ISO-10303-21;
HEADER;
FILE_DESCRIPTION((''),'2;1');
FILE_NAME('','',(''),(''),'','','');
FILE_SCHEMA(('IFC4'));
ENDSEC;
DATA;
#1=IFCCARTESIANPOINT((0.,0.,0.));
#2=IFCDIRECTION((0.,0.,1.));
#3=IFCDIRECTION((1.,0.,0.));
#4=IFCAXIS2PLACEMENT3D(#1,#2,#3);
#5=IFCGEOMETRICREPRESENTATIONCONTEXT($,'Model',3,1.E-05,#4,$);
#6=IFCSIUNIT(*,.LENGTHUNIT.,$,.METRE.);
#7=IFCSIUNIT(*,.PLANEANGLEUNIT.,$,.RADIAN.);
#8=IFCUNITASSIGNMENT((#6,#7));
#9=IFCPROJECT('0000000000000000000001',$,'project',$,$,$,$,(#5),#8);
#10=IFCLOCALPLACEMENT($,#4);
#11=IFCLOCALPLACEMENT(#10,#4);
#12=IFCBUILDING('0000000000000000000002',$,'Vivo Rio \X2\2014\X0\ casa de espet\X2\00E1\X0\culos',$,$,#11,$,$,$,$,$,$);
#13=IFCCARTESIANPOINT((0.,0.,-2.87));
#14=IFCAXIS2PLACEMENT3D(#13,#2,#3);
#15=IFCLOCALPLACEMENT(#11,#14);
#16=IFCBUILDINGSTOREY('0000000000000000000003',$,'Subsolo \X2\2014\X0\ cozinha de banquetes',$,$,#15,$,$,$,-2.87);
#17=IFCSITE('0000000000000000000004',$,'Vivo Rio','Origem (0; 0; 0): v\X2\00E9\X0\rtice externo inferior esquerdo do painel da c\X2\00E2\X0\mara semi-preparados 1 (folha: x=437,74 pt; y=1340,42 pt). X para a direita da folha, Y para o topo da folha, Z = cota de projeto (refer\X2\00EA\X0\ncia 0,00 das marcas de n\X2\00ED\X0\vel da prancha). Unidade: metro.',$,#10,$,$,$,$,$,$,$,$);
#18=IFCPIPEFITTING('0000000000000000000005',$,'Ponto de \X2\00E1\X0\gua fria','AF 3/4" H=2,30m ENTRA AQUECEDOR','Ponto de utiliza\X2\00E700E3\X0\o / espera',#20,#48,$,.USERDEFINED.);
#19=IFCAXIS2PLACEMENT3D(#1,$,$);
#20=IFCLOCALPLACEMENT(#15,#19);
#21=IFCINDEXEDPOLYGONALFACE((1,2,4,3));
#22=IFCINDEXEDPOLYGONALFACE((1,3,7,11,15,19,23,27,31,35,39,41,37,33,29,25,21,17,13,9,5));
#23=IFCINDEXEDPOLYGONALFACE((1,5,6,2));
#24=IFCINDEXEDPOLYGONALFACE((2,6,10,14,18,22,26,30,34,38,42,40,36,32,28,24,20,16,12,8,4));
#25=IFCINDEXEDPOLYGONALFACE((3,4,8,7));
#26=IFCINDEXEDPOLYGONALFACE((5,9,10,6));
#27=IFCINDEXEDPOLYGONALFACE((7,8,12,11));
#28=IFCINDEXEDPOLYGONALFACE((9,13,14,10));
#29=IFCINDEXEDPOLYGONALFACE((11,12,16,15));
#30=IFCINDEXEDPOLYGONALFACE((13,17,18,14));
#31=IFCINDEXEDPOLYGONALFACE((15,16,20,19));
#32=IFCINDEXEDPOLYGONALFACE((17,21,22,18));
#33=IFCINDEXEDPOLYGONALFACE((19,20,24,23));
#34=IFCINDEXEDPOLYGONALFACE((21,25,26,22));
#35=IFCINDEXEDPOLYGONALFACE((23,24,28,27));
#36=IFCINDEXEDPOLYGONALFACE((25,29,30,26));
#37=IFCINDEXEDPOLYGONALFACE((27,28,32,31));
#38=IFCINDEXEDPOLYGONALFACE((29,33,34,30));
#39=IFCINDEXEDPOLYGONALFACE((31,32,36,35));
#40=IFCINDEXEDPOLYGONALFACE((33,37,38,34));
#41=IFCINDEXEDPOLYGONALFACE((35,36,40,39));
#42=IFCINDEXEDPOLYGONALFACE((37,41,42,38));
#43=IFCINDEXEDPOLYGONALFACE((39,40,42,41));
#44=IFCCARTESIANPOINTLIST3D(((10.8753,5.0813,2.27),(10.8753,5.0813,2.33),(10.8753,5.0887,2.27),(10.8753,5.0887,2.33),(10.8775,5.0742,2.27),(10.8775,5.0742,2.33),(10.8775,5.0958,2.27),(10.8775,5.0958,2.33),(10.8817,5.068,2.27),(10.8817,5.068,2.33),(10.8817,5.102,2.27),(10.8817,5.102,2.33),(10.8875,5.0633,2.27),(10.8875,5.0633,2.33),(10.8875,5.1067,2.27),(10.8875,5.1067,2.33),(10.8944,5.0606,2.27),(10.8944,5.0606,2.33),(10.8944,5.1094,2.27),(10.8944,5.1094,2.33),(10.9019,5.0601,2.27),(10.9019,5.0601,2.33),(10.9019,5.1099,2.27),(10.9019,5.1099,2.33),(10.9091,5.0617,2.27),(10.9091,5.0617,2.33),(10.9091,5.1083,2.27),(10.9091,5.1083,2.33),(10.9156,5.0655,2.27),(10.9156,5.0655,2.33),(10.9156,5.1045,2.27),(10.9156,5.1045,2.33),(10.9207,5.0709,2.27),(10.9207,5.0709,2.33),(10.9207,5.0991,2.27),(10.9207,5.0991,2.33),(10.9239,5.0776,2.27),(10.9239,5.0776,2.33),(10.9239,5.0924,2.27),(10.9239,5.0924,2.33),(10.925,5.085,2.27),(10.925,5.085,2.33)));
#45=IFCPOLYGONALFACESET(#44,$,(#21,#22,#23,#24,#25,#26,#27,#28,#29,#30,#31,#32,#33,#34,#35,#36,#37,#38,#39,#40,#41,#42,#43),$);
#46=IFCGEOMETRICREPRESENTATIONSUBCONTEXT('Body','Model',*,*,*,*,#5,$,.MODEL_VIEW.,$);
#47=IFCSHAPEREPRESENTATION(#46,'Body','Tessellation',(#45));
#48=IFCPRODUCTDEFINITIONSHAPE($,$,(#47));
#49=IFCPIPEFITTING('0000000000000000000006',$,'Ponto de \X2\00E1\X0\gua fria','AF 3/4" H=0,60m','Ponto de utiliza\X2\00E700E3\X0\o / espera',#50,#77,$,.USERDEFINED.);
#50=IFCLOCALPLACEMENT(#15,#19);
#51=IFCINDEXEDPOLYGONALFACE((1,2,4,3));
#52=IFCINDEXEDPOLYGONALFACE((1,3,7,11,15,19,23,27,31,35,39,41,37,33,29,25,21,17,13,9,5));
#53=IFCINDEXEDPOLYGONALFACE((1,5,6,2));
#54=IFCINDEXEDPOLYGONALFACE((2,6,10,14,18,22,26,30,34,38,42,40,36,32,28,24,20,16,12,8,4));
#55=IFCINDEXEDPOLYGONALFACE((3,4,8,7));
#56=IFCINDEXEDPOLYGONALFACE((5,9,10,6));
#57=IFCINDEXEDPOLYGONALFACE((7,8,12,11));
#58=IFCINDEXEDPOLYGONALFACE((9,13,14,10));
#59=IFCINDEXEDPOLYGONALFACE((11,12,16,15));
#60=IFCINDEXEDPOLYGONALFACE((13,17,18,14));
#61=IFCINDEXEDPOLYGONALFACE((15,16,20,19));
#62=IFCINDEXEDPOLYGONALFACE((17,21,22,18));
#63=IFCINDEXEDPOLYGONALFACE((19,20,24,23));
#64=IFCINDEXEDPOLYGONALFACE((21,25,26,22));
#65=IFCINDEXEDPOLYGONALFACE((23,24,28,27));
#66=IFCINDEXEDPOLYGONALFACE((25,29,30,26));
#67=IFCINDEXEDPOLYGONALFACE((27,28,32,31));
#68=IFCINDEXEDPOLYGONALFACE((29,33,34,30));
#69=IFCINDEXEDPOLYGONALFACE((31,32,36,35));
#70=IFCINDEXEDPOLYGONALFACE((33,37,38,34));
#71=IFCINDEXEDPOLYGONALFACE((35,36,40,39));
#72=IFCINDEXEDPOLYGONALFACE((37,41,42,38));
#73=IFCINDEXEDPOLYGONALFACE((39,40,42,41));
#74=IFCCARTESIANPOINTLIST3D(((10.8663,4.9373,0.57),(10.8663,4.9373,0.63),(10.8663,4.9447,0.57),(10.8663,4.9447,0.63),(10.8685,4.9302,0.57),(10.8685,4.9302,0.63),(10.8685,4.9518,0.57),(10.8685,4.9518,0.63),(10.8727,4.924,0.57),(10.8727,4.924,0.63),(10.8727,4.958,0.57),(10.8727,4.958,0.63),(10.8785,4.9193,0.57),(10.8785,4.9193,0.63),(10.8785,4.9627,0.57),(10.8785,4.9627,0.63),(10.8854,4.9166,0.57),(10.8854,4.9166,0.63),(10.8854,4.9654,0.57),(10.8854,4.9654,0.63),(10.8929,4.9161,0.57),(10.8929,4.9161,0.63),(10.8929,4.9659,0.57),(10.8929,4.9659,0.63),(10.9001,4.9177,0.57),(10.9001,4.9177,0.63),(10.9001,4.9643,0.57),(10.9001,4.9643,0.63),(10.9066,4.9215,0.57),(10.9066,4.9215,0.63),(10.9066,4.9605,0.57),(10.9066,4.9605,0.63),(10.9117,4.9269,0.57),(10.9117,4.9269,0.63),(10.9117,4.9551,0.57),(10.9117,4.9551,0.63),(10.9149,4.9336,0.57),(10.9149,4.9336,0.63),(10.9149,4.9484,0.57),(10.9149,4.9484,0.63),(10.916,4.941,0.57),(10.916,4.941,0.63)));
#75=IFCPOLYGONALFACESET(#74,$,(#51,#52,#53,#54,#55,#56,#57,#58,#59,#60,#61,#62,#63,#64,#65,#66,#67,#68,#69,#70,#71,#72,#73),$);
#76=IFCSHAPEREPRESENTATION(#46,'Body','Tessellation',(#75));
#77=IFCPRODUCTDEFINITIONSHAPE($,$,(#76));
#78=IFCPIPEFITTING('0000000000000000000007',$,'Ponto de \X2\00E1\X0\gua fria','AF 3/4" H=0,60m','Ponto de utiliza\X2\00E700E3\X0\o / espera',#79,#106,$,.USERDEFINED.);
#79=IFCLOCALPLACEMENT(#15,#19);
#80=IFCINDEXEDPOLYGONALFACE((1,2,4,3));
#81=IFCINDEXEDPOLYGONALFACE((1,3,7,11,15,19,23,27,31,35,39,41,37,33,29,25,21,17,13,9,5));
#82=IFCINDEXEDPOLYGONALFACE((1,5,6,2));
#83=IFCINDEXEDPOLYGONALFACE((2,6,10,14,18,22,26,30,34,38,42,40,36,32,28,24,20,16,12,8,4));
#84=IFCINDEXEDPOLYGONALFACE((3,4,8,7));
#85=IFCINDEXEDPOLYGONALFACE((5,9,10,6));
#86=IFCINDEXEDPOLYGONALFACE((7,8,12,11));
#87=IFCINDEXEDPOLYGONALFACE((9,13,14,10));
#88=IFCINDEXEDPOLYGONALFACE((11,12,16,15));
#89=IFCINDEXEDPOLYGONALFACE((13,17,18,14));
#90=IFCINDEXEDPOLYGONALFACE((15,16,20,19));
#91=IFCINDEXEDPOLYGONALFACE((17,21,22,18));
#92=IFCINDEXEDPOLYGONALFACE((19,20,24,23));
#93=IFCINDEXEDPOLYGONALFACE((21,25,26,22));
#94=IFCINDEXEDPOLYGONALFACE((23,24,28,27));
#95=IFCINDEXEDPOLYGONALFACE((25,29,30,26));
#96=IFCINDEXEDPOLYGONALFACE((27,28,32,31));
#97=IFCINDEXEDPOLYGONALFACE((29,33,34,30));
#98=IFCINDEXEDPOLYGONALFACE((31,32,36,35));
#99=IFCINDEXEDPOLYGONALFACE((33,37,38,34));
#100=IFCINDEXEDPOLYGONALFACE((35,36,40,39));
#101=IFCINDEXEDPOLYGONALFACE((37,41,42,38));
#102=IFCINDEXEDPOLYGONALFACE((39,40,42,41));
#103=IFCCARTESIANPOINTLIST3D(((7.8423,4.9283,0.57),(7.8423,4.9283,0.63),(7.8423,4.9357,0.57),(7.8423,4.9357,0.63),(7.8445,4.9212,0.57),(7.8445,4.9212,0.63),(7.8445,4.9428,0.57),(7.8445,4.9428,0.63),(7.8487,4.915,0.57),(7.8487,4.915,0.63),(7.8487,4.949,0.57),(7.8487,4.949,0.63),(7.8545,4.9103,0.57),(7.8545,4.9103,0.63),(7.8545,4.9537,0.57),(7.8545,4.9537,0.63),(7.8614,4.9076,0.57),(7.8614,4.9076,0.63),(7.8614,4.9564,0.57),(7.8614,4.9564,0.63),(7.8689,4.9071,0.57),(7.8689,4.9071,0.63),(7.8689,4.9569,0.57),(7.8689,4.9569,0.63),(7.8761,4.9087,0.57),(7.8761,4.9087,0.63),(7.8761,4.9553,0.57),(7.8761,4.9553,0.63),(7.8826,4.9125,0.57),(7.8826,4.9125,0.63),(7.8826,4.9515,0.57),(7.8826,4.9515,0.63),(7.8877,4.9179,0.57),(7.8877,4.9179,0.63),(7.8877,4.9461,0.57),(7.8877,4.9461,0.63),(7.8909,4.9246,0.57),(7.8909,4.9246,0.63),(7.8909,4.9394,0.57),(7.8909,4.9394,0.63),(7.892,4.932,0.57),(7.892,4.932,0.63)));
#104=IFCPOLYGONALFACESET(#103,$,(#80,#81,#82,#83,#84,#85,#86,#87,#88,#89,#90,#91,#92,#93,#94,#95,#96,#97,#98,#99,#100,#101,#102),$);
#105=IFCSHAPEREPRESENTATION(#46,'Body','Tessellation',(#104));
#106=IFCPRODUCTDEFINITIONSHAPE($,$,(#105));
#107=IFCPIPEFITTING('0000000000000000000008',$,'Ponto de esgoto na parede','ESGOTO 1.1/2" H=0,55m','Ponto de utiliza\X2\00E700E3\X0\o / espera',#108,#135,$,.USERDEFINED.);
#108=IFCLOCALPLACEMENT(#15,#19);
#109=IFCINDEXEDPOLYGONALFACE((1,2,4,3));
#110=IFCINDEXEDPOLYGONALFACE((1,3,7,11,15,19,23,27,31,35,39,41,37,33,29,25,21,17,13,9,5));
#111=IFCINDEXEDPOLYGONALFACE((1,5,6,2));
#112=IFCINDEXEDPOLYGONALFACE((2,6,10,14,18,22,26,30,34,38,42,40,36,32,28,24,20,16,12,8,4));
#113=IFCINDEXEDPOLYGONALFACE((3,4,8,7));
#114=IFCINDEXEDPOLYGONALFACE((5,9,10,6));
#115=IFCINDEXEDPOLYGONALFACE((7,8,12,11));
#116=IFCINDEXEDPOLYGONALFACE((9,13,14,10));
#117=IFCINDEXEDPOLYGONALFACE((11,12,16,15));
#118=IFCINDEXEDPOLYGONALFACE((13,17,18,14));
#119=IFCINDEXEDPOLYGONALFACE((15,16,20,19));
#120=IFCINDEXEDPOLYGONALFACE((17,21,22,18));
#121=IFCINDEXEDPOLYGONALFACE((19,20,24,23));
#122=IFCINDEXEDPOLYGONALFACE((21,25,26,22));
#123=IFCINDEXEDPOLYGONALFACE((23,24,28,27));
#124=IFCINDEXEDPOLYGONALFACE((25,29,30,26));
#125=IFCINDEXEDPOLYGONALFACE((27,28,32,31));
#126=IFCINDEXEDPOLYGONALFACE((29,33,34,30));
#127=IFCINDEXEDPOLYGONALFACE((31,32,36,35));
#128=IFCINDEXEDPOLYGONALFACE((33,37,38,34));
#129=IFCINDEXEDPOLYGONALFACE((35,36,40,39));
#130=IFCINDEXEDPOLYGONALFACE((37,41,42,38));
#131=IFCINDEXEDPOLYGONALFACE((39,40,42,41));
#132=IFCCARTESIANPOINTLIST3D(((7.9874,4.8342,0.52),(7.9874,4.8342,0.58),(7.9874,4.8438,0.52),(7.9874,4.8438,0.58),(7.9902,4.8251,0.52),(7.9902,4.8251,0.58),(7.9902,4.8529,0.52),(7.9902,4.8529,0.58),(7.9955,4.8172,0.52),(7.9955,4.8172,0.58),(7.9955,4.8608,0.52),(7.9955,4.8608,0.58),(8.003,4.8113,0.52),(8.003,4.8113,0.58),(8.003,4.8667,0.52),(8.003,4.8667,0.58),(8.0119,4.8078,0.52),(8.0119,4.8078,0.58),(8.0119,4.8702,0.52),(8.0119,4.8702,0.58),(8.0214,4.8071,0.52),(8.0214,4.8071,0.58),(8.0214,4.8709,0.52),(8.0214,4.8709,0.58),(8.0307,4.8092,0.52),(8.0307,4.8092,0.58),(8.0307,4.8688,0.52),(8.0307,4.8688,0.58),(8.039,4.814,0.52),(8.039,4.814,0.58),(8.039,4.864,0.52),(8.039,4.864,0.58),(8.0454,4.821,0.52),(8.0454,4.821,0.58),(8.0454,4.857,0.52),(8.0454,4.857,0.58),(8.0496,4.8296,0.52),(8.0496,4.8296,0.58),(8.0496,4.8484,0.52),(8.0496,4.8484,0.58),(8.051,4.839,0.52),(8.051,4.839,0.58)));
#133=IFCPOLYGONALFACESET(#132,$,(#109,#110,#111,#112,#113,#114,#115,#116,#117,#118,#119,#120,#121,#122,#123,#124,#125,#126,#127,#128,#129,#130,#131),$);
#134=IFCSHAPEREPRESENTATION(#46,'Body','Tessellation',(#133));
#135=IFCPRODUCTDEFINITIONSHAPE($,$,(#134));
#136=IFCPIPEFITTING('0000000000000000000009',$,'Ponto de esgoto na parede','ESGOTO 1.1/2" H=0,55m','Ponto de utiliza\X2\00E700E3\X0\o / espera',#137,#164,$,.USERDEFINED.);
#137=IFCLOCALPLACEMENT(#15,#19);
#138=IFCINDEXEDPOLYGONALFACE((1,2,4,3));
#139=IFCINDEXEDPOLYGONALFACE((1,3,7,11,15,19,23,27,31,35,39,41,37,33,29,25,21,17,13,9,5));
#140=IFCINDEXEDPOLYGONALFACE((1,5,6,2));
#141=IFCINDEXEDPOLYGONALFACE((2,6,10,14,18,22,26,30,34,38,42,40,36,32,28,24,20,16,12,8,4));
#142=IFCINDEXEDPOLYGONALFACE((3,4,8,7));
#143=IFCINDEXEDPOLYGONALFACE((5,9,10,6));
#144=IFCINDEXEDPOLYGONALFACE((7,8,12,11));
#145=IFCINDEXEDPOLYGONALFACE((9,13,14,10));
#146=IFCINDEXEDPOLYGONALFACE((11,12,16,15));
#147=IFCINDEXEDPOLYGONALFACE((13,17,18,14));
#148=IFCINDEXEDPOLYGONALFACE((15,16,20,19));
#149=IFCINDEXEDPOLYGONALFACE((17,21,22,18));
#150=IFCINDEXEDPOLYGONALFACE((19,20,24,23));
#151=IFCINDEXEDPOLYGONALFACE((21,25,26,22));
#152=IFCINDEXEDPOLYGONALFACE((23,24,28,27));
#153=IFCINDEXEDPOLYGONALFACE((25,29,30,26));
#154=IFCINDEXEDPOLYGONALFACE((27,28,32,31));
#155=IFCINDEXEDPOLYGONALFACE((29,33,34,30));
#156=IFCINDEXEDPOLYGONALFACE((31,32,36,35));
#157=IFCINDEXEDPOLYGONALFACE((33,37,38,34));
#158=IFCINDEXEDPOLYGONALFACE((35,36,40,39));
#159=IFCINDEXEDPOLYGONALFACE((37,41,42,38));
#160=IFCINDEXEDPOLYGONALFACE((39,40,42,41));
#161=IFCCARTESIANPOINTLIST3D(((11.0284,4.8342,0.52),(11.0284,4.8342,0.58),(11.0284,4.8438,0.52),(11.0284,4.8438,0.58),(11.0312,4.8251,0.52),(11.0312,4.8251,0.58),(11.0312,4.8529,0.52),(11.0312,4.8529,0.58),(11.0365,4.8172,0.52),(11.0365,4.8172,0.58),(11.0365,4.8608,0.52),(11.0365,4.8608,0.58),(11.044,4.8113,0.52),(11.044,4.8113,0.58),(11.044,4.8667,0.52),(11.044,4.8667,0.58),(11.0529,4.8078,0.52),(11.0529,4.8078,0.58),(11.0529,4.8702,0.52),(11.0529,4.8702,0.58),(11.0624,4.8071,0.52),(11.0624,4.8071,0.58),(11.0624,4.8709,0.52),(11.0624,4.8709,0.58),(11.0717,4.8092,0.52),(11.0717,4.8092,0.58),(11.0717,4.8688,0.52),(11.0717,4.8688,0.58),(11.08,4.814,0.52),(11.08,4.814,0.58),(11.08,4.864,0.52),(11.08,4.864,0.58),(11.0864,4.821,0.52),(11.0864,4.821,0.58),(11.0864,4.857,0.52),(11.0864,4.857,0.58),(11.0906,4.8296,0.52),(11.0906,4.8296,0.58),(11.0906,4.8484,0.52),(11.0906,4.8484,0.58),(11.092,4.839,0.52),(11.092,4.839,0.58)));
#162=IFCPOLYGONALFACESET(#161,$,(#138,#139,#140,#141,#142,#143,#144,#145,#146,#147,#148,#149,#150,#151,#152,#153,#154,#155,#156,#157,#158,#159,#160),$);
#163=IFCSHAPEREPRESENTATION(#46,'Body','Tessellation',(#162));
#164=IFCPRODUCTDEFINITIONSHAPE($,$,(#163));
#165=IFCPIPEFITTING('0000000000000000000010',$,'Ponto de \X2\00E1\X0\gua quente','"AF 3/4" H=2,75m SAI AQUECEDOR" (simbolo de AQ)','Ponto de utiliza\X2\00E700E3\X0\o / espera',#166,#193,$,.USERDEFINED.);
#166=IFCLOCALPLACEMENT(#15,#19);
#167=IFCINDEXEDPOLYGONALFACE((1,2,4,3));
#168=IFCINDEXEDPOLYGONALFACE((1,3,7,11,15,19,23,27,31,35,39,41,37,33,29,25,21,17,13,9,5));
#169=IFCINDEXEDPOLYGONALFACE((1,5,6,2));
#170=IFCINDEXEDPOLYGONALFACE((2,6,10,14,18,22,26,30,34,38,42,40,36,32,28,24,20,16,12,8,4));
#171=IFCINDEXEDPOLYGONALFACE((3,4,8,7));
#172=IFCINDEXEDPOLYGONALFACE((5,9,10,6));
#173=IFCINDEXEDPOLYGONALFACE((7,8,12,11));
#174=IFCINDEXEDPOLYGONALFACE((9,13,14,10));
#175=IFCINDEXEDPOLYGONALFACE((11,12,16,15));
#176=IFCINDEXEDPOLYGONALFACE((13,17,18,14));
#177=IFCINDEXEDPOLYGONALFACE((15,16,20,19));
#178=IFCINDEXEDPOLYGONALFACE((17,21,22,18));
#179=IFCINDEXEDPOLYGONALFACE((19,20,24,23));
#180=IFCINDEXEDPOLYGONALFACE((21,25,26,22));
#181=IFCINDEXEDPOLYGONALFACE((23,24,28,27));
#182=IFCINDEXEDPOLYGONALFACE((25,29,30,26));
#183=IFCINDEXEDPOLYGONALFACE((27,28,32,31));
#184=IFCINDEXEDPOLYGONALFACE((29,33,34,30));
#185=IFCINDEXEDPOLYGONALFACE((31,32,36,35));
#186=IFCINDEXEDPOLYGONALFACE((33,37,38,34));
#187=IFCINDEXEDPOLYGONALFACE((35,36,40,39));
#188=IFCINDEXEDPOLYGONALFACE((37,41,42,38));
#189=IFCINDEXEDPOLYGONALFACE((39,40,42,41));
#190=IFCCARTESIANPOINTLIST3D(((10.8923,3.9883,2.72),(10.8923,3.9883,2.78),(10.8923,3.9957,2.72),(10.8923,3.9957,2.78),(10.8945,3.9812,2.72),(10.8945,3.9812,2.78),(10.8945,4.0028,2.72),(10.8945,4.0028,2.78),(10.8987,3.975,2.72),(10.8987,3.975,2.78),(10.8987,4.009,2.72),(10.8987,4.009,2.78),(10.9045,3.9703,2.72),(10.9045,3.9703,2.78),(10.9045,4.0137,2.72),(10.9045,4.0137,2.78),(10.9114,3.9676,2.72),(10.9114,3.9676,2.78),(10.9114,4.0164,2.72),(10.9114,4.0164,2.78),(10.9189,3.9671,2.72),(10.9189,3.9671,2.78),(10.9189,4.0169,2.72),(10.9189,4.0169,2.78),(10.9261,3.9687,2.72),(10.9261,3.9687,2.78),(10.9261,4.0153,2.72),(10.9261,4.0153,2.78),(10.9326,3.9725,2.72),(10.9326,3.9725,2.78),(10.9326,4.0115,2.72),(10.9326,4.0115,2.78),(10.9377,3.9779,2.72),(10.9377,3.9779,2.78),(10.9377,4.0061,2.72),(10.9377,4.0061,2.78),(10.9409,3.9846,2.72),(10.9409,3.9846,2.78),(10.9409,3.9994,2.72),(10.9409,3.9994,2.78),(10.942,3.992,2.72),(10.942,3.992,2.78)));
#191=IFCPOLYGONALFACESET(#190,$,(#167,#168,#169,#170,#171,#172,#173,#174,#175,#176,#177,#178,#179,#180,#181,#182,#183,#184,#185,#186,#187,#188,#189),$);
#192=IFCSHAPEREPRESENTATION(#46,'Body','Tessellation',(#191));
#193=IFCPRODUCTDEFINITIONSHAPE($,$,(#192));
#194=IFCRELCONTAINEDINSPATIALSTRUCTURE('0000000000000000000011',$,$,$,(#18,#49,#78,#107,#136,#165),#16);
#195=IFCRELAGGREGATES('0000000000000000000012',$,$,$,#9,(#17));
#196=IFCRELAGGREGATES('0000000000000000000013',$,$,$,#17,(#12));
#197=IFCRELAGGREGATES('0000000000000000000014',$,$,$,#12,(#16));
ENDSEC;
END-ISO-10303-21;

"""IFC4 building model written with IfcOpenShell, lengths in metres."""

from ifc_helpers import new_model, si_unit, frame, origin_with_axes, origin_2d, place, context, subcontext, project, spatial, circle, extrude, element, save


model = new_model("IFC4")

# Units and contexts
model_context = context("Model", 3, precision=1e-05, world=origin_with_axes())
body_context = subcontext(model_context, "Body", "Model", "MODEL_VIEW")
ifc_project = project(units=[si_unit("LENGTHUNIT", "METRE"), si_unit("PLANEANGLEUNIT", "RADIAN")], contexts=[model_context])

# Site, building, storey
site_placement = place(None, origin_with_axes())
site = spatial("IfcSite", under=ifc_project, at=site_placement, Name="Vivo Rio", Description="Origem (0; 0; 0): vértice externo inferior esquerdo do painel da câmara semi-preparados 1 (folha: x=437,74 pt; y=1340,42 pt). X para a direita da folha, Y para o topo da folha, Z = cota de projeto (referência 0,00 das marcas de nível da prancha). Unidade: metro.")
building_placement = place(site_placement, origin_with_axes())
building = spatial("IfcBuilding", under=site, at=building_placement, Name="Vivo Rio — casa de espetáculos")
storey_placement = place(building_placement, frame((0.0, 0.0, -2.87), z_axis=(0.0, 0.0, 1.0), x_axis=(1.0, 0.0, 0.0)))
storey = spatial("IfcBuildingStorey", under=building, at=storey_placement, Name="Subsolo — cozinha de banquetes", Elevation=-2.87)

# Pipe fittings
pipe_fitting_1_placement = place(storey_placement, origin_with_axes())
element("IfcPipeFitting", 1, at=pipe_fitting_1_placement, inside=storey, Name="Ponto de água fria", Description="AF 3/4\" H=2,30m ENTRA AQUECEDOR", ObjectType="Ponto de utilização / espera", PredefinedType="USERDEFINED", context=body_context, shape_type="SweptSolid", body=[
    extrude(circle(Radius=0.025, at=origin_2d()), frame((10.9, 5.085, 2.27), z_axis=(0.0, 0.0, 1.0), x_axis=(1.0, 0.0, 0.0)), (0.0, 0.0, 1.0), 0.06),
])
pipe_fitting_2_placement = place(storey_placement, origin_with_axes())
element("IfcPipeFitting", 2, at=pipe_fitting_2_placement, inside=storey, Name="Ponto de água fria", Description="AF 3/4\" H=0,60m", ObjectType="Ponto de utilização / espera", PredefinedType="USERDEFINED", context=body_context, shape_type="SweptSolid", body=[
    extrude(circle(Radius=0.025, at=origin_2d()), frame((10.891, 4.941, 0.57), z_axis=(0.0, 0.0, 1.0), x_axis=(1.0, 0.0, 0.0)), (0.0, 0.0, 1.0), 0.06),
])
pipe_fitting_3_placement = place(storey_placement, origin_with_axes())
element("IfcPipeFitting", 3, at=pipe_fitting_3_placement, inside=storey, Name="Ponto de água fria", Description="AF 3/4\" H=0,60m", ObjectType="Ponto de utilização / espera", PredefinedType="USERDEFINED", context=body_context, shape_type="SweptSolid", body=[
    extrude(circle(Radius=0.025, at=origin_2d()), frame((7.867, 4.932, 0.57), z_axis=(0.0, 0.0, 1.0), x_axis=(1.0, 0.0, 0.0)), (0.0, 0.0, 1.0), 0.06),
])
pipe_fitting_4_placement = place(storey_placement, origin_with_axes())
element("IfcPipeFitting", 4, at=pipe_fitting_4_placement, inside=storey, Name="Ponto de esgoto na parede", Description="ESGOTO 1.1/2\" H=0,55m", ObjectType="Ponto de utilização / espera", PredefinedType="USERDEFINED", context=body_context, shape_type="SweptSolid", body=[
    extrude(circle(Radius=0.032, at=origin_2d()), frame((8.019, 4.839, 0.52), z_axis=(0.0, 0.0, 1.0), x_axis=(1.0, 0.0, 0.0)), (0.0, 0.0, 1.0), 0.06),
])
pipe_fitting_5_placement = place(storey_placement, origin_with_axes())
element("IfcPipeFitting", 5, at=pipe_fitting_5_placement, inside=storey, Name="Ponto de esgoto na parede", Description="ESGOTO 1.1/2\" H=0,55m", ObjectType="Ponto de utilização / espera", PredefinedType="USERDEFINED", context=body_context, shape_type="SweptSolid", body=[
    extrude(circle(Radius=0.032, at=origin_2d()), frame((11.06, 4.839, 0.52), z_axis=(0.0, 0.0, 1.0), x_axis=(1.0, 0.0, 0.0)), (0.0, 0.0, 1.0), 0.06),
])
pipe_fitting_6_placement = place(storey_placement, origin_with_axes())
element("IfcPipeFitting", 6, at=pipe_fitting_6_placement, inside=storey, Name="Ponto de água quente", Description="\"AF 3/4\" H=2,75m SAI AQUECEDOR\" (simbolo de AQ)", ObjectType="Ponto de utilização / espera", PredefinedType="USERDEFINED", context=body_context, shape_type="SweptSolid", body=[
    extrude(circle(Radius=0.025, at=origin_2d()), frame((10.917, 3.992, 2.72), z_axis=(0.0, 0.0, 1.0), x_axis=(1.0, 0.0, 0.0)), (0.0, 0.0, 1.0), 0.06),
])

save(model, "model.ifc")
